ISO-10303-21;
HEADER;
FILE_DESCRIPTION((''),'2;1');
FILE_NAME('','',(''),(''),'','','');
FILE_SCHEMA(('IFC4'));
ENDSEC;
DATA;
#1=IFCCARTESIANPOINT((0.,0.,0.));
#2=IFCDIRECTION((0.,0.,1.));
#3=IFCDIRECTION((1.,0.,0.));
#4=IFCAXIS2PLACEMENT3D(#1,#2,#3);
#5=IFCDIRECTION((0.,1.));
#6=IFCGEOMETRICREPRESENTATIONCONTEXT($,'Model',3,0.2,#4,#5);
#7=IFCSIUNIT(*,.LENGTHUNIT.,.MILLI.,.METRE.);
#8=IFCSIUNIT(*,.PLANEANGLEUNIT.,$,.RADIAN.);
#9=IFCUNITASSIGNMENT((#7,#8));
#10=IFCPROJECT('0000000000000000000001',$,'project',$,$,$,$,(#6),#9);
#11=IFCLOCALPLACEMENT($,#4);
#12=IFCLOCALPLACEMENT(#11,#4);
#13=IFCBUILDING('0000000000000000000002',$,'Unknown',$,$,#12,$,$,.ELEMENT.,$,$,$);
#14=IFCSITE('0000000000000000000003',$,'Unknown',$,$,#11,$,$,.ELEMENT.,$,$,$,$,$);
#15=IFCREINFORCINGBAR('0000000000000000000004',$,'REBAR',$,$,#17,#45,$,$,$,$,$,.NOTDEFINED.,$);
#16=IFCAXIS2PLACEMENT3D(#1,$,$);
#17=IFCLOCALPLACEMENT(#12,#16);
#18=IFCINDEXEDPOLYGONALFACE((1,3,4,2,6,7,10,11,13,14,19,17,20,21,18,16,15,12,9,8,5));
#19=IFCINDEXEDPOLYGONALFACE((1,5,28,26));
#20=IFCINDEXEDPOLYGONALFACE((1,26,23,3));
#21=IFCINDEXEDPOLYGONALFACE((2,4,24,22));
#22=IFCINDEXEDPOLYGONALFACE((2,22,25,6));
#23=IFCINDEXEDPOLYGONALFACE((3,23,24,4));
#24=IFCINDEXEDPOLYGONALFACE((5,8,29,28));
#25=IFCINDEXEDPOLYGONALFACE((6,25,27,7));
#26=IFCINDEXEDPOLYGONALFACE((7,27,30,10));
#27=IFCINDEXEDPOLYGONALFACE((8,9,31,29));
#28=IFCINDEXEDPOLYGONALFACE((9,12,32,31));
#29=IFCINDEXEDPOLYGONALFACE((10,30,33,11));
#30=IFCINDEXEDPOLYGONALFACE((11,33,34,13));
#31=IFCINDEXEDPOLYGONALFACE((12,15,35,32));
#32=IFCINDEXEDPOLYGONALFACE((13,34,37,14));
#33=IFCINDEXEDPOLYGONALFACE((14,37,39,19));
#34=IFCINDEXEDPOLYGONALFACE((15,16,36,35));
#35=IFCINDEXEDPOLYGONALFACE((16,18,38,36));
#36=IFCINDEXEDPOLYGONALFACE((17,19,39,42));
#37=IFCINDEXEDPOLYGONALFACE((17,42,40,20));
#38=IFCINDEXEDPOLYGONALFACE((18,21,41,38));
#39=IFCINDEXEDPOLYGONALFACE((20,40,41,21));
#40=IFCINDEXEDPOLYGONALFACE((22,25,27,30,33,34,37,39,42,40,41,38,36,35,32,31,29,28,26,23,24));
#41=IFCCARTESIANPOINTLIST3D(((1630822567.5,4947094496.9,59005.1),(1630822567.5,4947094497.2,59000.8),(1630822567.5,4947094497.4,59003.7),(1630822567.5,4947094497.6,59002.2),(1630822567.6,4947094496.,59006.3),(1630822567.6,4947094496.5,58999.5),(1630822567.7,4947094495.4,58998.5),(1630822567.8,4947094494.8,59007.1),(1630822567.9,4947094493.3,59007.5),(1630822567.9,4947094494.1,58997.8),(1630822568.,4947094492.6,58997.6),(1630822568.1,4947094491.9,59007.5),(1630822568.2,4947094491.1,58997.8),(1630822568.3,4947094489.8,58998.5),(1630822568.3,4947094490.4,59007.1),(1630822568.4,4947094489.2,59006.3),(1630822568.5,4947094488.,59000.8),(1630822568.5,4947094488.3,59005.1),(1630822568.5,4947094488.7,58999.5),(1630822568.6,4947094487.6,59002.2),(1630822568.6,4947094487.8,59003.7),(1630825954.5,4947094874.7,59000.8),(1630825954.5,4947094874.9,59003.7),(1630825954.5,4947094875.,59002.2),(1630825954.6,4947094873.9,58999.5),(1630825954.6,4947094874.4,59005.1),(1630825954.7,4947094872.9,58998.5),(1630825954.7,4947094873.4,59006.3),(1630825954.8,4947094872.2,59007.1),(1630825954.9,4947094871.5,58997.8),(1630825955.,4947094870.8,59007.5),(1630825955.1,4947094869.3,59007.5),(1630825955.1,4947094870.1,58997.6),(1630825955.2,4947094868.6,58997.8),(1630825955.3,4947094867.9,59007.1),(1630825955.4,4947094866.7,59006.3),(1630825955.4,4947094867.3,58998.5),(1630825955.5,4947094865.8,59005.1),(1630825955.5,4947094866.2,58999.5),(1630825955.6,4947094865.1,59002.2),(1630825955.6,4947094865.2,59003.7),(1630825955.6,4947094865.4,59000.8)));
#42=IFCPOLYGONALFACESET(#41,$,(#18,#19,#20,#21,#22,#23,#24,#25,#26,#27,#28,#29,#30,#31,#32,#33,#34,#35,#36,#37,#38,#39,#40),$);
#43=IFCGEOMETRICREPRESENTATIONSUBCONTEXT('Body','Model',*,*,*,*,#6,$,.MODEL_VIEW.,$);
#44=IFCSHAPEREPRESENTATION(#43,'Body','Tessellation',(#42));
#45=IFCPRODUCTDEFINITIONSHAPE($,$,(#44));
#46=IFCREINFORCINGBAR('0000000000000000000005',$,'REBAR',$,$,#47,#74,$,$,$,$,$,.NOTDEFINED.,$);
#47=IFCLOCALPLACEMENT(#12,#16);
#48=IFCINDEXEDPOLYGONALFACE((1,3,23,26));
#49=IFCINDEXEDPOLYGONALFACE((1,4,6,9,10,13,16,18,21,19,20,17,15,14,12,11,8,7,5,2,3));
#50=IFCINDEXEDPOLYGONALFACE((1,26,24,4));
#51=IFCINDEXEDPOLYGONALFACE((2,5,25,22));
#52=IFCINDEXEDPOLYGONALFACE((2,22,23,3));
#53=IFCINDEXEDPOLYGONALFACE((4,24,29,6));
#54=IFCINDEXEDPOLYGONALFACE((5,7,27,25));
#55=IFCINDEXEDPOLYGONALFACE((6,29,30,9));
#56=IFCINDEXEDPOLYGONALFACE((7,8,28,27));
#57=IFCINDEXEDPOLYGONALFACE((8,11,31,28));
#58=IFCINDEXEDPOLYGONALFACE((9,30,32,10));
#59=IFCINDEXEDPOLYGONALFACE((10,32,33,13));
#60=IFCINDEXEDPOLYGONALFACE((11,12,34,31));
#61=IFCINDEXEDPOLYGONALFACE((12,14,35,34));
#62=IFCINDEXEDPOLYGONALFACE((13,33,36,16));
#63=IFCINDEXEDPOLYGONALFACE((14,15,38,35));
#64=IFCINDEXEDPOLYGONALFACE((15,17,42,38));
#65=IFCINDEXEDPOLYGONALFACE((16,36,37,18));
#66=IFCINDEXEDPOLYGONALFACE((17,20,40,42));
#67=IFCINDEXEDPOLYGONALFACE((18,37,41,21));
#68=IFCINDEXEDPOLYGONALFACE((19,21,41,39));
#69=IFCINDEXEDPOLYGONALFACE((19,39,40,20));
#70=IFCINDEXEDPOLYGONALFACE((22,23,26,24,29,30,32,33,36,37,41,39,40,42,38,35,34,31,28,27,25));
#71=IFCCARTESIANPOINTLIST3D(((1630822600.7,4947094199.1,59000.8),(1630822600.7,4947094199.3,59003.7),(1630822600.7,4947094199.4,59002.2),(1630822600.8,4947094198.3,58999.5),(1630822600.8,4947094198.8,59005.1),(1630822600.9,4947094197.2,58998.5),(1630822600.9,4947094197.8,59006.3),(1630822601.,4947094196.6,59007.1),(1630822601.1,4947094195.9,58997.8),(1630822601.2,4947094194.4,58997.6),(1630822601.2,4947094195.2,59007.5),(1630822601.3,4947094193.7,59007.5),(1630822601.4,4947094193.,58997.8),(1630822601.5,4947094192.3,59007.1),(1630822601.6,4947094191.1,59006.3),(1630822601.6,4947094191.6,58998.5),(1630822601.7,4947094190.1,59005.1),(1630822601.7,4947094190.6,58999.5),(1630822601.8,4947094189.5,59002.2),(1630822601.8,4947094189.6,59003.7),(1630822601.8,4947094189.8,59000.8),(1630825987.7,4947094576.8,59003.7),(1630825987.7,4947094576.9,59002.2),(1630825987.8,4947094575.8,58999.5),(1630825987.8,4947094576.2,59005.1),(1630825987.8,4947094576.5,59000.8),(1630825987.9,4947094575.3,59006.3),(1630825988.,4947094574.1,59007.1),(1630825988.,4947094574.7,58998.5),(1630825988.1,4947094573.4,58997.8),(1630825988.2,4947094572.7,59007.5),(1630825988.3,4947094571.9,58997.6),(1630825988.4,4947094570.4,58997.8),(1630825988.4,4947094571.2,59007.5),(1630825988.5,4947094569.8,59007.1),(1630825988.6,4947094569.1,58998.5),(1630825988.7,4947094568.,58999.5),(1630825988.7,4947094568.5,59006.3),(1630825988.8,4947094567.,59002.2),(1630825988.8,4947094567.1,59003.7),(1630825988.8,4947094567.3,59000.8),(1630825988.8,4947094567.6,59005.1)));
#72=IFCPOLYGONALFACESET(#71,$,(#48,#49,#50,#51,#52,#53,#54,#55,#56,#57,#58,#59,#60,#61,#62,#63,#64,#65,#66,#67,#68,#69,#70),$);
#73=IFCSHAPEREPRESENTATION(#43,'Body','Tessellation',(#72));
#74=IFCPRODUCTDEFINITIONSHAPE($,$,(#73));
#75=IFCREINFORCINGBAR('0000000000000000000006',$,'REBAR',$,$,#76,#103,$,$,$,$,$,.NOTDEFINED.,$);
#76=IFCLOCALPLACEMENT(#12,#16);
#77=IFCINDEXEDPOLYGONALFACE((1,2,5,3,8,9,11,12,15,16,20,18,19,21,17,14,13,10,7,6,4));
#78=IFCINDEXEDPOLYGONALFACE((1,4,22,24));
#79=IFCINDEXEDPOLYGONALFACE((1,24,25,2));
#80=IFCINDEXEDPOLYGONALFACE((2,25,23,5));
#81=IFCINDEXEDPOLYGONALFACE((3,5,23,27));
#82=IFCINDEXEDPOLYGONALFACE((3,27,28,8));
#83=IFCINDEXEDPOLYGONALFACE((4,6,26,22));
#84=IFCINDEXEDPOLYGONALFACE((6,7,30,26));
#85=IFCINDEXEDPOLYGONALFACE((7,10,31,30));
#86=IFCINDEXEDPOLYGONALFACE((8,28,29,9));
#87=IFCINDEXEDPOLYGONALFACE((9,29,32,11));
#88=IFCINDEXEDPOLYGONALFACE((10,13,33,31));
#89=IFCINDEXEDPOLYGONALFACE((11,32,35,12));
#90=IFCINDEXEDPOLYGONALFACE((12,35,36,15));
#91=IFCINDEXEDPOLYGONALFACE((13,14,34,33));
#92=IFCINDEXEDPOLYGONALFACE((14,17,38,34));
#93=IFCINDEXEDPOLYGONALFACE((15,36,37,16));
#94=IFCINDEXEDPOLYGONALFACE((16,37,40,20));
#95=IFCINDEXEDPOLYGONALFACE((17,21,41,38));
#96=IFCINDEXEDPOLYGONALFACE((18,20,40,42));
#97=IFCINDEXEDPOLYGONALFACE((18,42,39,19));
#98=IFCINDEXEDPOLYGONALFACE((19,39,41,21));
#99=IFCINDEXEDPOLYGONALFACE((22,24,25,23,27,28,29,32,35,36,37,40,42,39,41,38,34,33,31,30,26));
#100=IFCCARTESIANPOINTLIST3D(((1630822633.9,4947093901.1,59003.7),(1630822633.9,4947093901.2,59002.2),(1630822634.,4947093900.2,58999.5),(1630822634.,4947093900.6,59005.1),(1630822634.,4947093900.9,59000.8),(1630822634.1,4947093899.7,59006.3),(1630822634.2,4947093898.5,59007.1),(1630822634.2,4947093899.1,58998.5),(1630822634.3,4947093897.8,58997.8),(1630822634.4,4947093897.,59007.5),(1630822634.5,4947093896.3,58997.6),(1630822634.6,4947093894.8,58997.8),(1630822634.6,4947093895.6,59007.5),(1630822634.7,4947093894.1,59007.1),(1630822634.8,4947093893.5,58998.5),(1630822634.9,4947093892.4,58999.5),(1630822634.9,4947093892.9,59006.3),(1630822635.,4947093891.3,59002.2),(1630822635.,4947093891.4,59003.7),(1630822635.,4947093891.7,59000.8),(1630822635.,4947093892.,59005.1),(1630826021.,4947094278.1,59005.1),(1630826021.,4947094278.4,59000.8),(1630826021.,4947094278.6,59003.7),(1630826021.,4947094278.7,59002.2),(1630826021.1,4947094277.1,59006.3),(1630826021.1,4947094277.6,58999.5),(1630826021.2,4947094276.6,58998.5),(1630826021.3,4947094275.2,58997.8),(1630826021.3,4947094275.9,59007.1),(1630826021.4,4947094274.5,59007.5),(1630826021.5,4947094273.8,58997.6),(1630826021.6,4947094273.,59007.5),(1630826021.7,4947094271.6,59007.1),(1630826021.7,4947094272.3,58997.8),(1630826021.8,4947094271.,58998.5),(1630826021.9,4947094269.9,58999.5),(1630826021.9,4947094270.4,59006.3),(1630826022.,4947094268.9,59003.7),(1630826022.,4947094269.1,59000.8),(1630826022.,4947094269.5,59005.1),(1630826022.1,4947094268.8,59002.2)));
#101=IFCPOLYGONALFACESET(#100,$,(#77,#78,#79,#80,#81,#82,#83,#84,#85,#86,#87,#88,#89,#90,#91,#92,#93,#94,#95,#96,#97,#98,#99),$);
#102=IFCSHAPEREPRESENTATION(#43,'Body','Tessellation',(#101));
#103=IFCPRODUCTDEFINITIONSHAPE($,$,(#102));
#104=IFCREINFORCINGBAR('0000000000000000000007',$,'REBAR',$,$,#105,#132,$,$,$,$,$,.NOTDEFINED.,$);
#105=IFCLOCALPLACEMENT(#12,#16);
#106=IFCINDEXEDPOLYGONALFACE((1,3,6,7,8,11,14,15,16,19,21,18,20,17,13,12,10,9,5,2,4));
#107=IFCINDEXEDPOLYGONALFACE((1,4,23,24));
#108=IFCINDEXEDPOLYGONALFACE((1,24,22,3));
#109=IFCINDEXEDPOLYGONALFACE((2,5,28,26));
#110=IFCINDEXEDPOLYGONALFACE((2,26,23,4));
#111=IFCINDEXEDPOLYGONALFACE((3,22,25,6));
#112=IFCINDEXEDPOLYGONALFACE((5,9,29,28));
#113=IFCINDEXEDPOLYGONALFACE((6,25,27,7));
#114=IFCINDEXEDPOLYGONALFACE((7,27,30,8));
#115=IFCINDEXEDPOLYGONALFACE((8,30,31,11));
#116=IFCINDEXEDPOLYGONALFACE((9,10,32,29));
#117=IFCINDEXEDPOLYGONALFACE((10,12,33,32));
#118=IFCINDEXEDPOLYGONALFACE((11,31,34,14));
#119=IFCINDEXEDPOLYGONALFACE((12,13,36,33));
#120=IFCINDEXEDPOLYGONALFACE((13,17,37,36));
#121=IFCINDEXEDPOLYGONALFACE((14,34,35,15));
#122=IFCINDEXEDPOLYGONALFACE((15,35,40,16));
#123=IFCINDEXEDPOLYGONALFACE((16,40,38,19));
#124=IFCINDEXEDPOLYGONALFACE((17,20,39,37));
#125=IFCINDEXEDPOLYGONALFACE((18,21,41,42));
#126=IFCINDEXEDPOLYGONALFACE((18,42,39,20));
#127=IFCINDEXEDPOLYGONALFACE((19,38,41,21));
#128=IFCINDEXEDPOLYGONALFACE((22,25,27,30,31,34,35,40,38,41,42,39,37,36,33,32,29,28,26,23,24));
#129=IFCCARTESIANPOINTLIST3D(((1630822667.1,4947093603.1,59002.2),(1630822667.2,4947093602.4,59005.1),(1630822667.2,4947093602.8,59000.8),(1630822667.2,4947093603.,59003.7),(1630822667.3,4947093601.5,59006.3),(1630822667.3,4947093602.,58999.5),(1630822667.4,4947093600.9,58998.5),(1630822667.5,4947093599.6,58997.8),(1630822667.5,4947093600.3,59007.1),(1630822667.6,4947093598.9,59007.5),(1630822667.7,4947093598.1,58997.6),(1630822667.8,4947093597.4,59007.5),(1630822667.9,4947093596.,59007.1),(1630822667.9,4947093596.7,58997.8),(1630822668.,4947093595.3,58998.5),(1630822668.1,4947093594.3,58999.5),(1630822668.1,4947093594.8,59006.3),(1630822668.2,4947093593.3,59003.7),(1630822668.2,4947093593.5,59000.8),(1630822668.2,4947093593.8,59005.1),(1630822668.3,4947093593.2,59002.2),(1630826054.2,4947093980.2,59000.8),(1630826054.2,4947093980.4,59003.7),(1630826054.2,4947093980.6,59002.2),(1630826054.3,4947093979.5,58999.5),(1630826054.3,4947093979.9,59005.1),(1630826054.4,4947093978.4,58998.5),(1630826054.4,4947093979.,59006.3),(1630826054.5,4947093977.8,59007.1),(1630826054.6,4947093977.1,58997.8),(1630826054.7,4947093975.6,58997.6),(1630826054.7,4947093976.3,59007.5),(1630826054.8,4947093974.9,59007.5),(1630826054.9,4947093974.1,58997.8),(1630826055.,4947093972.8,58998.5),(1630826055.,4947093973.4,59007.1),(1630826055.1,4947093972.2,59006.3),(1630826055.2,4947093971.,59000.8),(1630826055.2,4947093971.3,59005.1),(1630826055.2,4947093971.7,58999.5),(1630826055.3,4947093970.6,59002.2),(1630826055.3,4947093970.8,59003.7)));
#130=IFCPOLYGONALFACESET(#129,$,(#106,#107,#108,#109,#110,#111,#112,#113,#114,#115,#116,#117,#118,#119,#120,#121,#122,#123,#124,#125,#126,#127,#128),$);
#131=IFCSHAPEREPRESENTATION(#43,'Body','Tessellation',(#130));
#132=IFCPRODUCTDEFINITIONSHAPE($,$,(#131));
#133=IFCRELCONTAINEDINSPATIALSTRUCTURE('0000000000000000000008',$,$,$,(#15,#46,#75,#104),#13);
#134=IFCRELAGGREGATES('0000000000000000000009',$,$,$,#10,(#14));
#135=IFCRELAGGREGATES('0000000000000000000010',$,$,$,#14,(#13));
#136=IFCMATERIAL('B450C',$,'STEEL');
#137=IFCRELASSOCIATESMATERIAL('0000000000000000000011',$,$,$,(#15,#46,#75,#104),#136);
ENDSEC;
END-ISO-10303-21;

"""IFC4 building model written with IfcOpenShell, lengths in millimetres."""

from ifc_helpers import new_model, entity, si_unit, direction, frame, origin_with_axes, place, context, subcontext, project, spatial, material, element, save


model = new_model("IFC4")

# Units and contexts
model_context = context("Model", 3, precision=0.2, world=origin_with_axes(), true_north=direction((0.0, 1.0)))
body_context = subcontext(model_context, "Body", "Model", "MODEL_VIEW")
ifc_project = project(units=[si_unit("LENGTHUNIT", "METRE", prefix="MILLI"), si_unit("PLANEANGLEUNIT", "RADIAN")], contexts=[model_context])

# Site, building
site_placement = place(None, origin_with_axes())
site = spatial("IfcSite", under=ifc_project, at=site_placement, Name="Unknown", CompositionType="ELEMENT")
building_placement = place(site_placement, origin_with_axes())
building = spatial("IfcBuilding", under=site, at=building_placement, Name="Unknown", CompositionType="ELEMENT")

# Reinforcing bars
ifc_material = material(Name="B450C", Category="STEEL")
reinforcing_bar_1_placement = place(building_placement, frame((1630825955.1, 4947094870.1, 59002.6), z_axis=(0.000031, -0.000282, -1.0), x_axis=(-0.993847, -0.110757, 0.0)))
element("IfcReinforcingBar", 1, at=reinforcing_bar_1_placement, inside=building, material=ifc_material, Name="REBAR", PredefinedType="NOTDEFINED", context=body_context, shape_type="AdvancedSweptSolid", body=[
    entity("IfcSweptDiskSolid", entity("IfcIndexedPolyCurve", entity("IfcCartesianPointList3D", [[0.0, 0.0, 0.0], [3408.0, 0.0, 0.0]]), [entity("IfcLineIndex", [1, 2])]), 5.0),
])
for number, where, z_axis, x_axis, name in (
    (2, (1630825988.3, 4947094571.9, 59002.6), (0.000031, -0.000282, -1.0), (-0.993847, -0.110757, 0.0), "REBAR"),
    (3, (1630826021.5, 4947094273.8, 59002.6), (0.000031, -0.000282, -1.0), (-0.993847, -0.110757, 0.0), "REBAR"),
    (4, (1630826054.7, 4947093975.6, 59002.6), (0.000031, -0.000282, -1.0), (-0.993847, -0.110757, 0.0), "REBAR"),
):
    element("IfcReinforcingBar", number, at=place(building_placement, frame(where, z_axis=z_axis, x_axis=x_axis)), inside=building, material=ifc_material, Name=name, PredefinedType="NOTDEFINED", context=body_context, shape_type="AdvancedSweptSolid", body=[
        entity("IfcSweptDiskSolid", entity("IfcIndexedPolyCurve", entity("IfcCartesianPointList3D", [[0.0, 0.0, 0.0], [3408.0, 0.0, 0.0]]), [entity("IfcLineIndex", [1, 2])]), 5.0),
    ])

save(model, "model.ifc")
